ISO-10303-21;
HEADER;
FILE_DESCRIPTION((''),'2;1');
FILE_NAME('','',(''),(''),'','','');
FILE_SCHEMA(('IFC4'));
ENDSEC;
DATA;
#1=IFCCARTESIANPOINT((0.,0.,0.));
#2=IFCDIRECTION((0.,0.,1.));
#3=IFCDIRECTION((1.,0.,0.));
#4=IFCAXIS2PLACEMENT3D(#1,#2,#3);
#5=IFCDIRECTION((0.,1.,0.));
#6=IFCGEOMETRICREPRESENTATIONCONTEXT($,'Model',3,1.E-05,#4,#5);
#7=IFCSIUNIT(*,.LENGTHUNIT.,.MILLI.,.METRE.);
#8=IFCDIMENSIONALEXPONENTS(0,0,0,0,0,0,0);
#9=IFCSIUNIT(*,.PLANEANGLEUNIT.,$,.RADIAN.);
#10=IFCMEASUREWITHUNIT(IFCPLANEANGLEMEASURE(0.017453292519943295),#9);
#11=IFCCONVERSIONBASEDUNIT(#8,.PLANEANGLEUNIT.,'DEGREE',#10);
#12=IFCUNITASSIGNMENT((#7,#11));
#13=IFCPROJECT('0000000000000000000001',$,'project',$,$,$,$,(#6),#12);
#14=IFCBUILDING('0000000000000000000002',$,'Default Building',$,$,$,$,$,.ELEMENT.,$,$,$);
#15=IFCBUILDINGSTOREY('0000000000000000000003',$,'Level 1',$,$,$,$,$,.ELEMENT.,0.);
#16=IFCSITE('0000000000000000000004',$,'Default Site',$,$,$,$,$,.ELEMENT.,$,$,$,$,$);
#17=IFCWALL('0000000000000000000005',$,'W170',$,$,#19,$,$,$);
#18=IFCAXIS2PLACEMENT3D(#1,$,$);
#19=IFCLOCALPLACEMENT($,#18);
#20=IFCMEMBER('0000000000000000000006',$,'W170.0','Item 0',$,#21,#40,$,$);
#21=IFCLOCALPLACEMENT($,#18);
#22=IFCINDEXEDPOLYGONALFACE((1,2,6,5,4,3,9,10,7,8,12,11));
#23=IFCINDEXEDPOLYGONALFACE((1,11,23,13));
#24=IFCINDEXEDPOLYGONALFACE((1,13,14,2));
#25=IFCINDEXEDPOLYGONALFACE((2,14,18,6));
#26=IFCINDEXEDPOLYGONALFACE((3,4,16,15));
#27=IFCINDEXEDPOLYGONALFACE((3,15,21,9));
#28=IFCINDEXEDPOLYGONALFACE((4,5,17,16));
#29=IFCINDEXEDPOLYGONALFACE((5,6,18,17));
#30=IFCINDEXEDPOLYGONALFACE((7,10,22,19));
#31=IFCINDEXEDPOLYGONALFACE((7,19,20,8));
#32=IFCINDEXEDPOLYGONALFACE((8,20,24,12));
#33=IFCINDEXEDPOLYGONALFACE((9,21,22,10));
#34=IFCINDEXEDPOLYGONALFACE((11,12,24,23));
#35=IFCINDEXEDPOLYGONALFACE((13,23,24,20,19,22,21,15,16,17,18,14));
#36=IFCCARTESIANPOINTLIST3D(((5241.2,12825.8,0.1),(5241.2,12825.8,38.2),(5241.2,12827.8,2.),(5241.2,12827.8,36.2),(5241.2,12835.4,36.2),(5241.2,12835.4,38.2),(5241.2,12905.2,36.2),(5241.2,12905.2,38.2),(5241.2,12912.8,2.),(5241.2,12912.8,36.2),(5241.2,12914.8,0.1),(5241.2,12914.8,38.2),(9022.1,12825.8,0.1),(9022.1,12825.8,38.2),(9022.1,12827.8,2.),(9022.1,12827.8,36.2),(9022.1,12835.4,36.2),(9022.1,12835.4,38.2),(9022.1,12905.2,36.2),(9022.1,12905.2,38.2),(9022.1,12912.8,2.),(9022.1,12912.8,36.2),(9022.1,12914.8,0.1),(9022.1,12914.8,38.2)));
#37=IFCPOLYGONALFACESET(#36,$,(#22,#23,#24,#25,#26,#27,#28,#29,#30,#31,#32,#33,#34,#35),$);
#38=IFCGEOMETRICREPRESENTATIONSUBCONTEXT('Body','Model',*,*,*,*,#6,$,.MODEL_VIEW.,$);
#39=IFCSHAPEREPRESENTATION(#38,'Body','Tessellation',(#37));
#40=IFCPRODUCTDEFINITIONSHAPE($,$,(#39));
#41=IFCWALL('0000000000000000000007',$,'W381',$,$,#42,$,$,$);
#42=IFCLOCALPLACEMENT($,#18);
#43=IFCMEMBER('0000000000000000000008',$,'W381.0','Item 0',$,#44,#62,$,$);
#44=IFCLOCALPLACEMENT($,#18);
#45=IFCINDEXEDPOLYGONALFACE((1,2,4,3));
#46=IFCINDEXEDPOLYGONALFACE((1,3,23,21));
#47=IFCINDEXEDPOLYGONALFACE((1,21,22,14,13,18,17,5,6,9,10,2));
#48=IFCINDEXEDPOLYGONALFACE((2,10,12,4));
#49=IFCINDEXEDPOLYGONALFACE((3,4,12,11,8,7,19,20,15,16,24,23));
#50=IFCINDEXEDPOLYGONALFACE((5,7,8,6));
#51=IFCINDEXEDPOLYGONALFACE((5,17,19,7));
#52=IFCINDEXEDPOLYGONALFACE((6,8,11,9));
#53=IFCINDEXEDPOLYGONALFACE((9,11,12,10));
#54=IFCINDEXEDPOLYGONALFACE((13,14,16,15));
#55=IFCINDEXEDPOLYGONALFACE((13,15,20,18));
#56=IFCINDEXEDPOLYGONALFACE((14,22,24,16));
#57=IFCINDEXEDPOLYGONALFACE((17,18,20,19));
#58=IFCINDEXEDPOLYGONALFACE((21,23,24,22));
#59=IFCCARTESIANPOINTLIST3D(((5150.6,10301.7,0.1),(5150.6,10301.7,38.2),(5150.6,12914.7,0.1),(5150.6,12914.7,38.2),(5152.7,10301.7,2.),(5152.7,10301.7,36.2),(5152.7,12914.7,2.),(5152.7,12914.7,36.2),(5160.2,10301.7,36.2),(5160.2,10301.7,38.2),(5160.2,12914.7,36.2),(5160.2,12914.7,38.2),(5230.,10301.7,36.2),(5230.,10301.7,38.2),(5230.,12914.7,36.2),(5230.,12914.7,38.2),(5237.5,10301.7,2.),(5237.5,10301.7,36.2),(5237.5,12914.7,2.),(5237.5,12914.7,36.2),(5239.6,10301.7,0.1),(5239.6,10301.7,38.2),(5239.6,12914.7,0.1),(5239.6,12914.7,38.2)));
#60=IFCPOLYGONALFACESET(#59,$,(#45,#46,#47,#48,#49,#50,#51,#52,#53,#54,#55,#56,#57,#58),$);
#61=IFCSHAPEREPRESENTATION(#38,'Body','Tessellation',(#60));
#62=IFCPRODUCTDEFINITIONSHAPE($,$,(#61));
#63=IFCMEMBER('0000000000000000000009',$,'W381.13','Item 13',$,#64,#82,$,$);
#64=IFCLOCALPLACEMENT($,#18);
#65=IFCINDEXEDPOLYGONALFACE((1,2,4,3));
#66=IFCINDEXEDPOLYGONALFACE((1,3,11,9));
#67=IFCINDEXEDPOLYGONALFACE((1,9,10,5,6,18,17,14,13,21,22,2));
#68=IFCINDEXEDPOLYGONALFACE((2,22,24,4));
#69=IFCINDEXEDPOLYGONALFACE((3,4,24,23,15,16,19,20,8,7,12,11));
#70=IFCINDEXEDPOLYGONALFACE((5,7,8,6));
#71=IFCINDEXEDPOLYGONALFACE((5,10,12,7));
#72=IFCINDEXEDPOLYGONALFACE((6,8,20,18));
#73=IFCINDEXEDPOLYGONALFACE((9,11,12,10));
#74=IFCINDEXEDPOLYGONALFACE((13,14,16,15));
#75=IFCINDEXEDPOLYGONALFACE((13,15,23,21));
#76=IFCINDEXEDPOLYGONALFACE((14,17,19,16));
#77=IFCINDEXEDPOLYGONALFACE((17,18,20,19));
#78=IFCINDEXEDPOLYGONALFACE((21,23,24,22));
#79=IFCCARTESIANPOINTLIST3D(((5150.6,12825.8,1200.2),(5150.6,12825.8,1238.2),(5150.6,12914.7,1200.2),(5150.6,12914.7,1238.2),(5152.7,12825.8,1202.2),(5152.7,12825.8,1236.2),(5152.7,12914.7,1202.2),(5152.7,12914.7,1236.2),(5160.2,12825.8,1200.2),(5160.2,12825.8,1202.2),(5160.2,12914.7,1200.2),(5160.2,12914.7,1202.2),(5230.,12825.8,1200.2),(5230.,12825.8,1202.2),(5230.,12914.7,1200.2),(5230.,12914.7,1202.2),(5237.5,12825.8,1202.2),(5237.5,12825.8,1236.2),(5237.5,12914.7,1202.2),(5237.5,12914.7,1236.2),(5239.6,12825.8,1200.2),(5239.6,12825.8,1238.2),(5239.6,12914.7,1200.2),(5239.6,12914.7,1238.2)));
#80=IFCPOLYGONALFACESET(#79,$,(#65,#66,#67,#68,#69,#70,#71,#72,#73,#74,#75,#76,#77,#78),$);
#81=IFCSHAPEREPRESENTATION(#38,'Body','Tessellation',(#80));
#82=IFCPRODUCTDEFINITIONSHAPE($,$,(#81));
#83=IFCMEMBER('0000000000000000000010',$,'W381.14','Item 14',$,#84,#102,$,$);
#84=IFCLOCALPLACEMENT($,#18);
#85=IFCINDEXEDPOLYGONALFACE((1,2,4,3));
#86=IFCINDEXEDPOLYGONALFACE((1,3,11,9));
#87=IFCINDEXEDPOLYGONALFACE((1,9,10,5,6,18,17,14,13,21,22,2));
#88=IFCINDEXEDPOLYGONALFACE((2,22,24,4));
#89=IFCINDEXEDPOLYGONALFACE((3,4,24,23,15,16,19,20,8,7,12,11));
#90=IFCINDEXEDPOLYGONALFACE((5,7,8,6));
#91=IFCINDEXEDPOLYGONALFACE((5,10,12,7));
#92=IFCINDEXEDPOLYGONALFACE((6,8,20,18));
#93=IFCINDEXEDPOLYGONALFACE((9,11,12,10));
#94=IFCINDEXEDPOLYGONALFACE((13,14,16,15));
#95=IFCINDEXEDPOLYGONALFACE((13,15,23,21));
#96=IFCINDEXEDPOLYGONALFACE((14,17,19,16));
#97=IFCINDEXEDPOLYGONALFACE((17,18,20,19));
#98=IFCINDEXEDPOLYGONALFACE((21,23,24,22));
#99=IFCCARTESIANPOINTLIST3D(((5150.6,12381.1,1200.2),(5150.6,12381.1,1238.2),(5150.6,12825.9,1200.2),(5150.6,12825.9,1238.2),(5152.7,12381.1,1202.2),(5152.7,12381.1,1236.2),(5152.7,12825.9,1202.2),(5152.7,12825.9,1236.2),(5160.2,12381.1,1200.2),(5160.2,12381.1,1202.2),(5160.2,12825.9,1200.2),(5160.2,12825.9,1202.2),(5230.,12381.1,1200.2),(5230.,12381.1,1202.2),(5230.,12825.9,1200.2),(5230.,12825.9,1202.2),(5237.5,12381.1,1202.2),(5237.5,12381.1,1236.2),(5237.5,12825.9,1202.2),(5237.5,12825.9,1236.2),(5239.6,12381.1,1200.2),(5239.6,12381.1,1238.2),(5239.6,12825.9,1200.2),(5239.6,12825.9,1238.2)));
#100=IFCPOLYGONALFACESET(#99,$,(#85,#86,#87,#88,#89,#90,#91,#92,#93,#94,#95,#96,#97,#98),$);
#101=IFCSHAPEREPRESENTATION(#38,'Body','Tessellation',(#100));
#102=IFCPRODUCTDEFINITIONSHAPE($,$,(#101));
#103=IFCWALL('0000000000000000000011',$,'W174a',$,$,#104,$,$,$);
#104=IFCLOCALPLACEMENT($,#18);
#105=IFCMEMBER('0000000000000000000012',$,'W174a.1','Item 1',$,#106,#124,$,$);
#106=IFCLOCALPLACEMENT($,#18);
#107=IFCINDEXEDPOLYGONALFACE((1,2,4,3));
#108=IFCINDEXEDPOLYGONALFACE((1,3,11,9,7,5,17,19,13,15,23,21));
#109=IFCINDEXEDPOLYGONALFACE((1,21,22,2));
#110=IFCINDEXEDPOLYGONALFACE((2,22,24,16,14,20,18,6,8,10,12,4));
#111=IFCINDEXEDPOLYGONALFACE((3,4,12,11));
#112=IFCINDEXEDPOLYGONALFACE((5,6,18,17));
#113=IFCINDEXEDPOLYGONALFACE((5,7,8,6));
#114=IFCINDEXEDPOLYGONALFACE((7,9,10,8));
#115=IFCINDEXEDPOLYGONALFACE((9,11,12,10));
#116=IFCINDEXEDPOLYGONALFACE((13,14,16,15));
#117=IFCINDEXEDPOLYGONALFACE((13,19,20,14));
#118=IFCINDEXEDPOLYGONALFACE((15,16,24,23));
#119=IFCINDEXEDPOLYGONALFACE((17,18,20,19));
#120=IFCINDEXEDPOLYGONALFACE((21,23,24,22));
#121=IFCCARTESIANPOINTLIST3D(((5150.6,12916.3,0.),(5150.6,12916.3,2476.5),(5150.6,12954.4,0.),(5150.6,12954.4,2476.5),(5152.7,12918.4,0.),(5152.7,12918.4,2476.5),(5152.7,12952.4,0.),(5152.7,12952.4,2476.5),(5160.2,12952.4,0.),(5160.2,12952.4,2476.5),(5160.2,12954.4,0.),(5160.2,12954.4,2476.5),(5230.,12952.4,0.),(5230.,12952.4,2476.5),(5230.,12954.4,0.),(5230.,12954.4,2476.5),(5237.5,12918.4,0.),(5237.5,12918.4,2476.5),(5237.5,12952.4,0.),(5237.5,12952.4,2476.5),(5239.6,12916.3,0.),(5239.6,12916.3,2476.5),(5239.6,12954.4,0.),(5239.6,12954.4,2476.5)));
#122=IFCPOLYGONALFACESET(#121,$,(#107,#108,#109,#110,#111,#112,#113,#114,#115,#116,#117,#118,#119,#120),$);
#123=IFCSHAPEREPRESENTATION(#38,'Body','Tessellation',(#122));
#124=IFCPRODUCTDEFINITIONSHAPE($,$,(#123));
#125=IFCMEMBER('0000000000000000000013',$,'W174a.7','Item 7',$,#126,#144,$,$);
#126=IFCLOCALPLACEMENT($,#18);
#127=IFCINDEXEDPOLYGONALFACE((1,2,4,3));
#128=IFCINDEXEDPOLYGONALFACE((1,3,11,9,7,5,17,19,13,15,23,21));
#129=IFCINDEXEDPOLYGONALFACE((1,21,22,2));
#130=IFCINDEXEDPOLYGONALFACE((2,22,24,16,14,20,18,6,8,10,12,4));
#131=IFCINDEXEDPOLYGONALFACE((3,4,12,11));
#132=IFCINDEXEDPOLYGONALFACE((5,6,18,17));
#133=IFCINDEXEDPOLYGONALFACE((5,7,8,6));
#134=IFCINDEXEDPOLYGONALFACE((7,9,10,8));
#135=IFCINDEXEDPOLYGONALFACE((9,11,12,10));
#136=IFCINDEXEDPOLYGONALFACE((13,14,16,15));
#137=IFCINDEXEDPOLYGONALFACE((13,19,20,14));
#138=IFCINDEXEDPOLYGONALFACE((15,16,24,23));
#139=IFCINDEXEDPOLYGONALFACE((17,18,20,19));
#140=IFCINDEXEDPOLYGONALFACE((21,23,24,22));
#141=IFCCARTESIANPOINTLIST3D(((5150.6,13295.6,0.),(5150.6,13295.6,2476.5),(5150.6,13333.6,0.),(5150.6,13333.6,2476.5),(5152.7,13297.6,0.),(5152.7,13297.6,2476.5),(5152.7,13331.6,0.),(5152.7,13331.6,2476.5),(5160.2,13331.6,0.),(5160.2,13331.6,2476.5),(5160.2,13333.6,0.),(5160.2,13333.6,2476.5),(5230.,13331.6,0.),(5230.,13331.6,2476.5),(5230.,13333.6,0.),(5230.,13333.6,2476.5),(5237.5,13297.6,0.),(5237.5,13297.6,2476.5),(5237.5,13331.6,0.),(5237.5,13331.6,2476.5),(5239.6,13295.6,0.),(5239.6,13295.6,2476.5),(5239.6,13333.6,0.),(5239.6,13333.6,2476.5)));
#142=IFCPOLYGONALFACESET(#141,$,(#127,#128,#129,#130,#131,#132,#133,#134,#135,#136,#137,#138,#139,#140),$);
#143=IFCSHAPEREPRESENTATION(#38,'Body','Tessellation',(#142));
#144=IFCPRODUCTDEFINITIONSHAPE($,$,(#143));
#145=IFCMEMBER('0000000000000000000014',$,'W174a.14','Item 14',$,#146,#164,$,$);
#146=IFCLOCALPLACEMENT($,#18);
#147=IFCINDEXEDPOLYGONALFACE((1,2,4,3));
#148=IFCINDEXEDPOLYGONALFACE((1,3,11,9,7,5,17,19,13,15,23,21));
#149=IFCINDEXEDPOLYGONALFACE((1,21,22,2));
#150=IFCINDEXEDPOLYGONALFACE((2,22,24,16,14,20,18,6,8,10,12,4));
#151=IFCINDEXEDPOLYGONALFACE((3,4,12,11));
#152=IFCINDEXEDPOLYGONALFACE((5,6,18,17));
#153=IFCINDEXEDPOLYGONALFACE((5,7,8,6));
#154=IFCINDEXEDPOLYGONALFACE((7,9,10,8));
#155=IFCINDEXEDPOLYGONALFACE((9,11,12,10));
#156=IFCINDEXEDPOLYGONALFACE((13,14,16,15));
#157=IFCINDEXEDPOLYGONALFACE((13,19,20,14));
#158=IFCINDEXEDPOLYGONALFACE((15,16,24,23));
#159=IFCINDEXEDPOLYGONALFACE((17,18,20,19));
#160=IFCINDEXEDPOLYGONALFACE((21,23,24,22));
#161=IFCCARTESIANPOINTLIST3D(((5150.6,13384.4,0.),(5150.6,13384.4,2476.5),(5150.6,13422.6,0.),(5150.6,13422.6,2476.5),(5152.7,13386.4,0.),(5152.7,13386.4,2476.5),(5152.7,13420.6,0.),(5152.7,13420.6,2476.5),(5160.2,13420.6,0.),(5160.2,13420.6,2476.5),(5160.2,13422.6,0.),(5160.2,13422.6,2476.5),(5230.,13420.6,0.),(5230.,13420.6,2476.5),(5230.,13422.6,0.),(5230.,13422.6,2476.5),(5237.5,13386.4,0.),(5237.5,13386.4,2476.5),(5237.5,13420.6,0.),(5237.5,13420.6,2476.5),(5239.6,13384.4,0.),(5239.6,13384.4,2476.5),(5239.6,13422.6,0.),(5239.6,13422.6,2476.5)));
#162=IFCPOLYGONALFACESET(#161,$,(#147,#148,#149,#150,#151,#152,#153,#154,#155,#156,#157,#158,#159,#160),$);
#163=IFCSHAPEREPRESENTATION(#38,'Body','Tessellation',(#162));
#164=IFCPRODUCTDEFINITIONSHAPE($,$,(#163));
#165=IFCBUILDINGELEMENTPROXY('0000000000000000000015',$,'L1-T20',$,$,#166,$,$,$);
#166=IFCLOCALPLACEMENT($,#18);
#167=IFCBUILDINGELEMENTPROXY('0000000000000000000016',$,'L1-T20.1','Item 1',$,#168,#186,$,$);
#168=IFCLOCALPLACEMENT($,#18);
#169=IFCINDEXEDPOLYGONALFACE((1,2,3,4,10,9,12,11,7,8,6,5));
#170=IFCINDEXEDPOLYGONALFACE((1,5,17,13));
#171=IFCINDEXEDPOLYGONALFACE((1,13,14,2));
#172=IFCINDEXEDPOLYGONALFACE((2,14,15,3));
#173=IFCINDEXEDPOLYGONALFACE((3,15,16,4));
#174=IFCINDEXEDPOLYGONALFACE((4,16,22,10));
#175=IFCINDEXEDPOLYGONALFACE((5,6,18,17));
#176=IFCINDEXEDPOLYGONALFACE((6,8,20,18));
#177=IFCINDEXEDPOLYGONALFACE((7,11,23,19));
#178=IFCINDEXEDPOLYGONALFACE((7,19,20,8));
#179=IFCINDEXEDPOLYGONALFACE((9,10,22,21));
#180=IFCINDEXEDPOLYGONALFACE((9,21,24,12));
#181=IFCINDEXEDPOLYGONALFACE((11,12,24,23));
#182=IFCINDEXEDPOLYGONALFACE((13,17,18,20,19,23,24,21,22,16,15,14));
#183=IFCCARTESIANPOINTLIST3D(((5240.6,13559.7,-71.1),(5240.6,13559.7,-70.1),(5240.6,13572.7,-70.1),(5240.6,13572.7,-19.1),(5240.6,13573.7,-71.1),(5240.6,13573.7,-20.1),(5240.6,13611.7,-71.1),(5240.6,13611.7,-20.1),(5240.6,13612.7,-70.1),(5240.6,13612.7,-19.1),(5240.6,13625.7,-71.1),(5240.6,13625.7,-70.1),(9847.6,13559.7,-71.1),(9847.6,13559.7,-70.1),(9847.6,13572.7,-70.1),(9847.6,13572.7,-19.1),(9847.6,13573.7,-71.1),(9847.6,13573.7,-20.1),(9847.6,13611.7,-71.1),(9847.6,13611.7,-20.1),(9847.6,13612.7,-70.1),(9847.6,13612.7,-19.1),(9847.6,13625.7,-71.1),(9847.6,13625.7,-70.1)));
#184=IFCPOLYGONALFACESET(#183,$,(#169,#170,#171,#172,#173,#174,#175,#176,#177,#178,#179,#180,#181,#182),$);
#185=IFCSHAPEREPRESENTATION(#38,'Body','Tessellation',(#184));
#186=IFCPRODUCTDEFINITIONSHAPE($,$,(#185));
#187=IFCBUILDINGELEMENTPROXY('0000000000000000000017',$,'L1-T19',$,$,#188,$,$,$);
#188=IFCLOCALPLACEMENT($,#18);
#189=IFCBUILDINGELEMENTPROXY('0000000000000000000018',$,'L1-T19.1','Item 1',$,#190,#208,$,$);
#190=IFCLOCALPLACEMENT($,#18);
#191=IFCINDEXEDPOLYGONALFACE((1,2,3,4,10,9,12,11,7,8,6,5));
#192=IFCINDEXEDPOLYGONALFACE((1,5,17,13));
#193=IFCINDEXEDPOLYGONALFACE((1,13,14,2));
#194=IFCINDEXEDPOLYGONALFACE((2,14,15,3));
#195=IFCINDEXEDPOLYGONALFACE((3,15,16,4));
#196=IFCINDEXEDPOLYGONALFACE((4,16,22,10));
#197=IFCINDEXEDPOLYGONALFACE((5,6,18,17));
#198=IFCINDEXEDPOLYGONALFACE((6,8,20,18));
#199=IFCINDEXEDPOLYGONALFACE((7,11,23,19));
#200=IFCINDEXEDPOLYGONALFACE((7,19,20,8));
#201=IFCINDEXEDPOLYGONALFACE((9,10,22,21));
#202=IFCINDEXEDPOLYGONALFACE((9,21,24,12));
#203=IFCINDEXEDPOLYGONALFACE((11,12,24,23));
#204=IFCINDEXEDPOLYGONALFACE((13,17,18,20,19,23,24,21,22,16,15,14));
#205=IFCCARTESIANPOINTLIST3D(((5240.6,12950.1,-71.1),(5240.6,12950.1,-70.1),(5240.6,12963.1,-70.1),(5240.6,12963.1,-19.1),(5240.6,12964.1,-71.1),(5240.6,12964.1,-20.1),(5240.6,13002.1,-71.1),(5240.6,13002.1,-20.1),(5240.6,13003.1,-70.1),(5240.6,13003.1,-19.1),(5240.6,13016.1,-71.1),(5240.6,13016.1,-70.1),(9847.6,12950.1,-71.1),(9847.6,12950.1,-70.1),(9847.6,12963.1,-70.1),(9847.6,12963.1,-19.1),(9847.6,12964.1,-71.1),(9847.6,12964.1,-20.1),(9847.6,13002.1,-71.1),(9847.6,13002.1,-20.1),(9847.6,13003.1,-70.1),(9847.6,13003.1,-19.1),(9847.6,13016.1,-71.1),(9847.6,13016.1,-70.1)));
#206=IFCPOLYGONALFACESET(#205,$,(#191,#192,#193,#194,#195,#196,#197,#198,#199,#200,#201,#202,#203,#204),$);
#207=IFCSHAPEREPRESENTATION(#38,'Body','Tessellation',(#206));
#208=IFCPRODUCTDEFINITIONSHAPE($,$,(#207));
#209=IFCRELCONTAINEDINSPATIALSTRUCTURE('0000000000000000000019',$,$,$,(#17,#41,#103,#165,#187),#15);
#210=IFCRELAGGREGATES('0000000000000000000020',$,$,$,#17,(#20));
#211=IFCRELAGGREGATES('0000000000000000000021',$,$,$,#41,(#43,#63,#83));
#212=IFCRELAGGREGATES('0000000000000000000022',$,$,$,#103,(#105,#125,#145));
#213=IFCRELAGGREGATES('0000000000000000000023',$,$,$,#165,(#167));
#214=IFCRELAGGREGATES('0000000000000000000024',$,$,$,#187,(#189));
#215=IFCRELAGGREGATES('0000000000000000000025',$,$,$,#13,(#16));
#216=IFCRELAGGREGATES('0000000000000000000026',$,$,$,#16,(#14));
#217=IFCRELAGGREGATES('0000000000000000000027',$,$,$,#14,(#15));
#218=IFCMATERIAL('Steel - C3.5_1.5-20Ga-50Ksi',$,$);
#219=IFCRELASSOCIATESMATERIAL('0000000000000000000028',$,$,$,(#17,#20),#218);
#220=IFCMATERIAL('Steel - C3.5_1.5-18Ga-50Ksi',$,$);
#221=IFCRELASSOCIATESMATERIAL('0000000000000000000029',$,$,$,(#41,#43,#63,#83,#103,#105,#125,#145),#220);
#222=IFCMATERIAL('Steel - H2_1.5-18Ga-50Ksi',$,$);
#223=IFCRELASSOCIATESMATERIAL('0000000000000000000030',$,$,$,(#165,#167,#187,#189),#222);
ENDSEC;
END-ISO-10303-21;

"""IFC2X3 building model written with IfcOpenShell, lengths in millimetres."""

from ifc_helpers import new_model, entity, si_unit, converted_unit, direction, frame, origin, origin_with_axes, origin_2d_with_axis, place, context, subcontext, project, spatial, polyline, c_section, outline, extrude, material, element, aggregate, save


model = new_model("IFC2X3")

# Units and contexts
model_context = context("Model", 3, precision=1e-05, world=origin_with_axes(), true_north=direction((0.0, 1.0, 0.0)))
body_context = subcontext(model_context, "Body", "Model", "MODEL_VIEW")
ifc_project = project(units=[si_unit("LENGTHUNIT", "METRE", prefix="MILLI"), converted_unit("PLANEANGLEUNIT", "DEGREE", entity("IfcPlaneAngleMeasure", 0.017453292519943295), si_unit("PLANEANGLEUNIT", "RADIAN"), dimensions=[0, 0, 0, 0, 0, 0, 0])], contexts=[model_context])

# Site, building, storey
site = spatial("IfcSite", under=ifc_project, Name="Default Site", CompositionType="ELEMENT")
building = spatial("IfcBuilding", under=site, Name="Default Building", CompositionType="ELEMENT")
storey = spatial("IfcBuildingStorey", under=building, Name="Level 1", CompositionType="ELEMENT", Elevation=0.0)

# Wall, member
ifc_material_1 = material(Name="Steel - C3.5_1.5-20Ga-50Ksi")
wall_1 = element("IfcWall", 1, inside=storey, material=ifc_material_1, Name="W170")
member_1_placement = place(None, frame((5241.2, 12870.3, 19.1), z_axis=(1.0, 0.0, 0.0), x_axis=(0.0, 0.0, 1.0)))
member_1 = element("IfcMember", 2, at=member_1_placement, material=ifc_material_1, Name="W170.0", Description="Item 0", context=body_context, shape_type="SweptSolid", body=[
    extrude(c_section(Depth=88.9, Width=38.1, WallThickness=2.0, Girth=9.5, at=origin_2d_with_axis()), origin(), (0.0, 0.0, 1.0), 3780.9),
])
aggregate(wall_1, [member_1])

# Walls, members
ifc_material_2 = material(Name="Steel - C3.5_1.5-18Ga-50Ksi")
wall_2 = element("IfcWall", 3, inside=storey, material=ifc_material_2, Name="W381")
member_2_placement = place(None, frame((5195.1, 12914.7, 19.1), z_axis=(0.0, -1.0, 0.0), x_axis=(0.0, 0.0, 1.0)))
member_2 = element("IfcMember", 4, at=member_2_placement, material=ifc_material_2, Name="W381.0", Description="Item 0", context=body_context, shape_type="SweptSolid", body=[
    extrude(c_section(Depth=88.9, Width=38.1, WallThickness=2.0, Girth=9.5, at=origin_2d_with_axis()), origin(), (0.0, 0.0, 1.0), 2613.0),
])
member_3_placement = place(None, frame((5195.1, 12825.8, 1219.2), z_axis=(0.0, 1.0, 0.0), x_axis=(0.0, 0.0, -1.0)))
member_3 = element("IfcMember", 5, at=member_3_placement, material=ifc_material_2, Name="W381.13", Description="Item 13", context=body_context, shape_type="SweptSolid", body=[
    extrude(c_section(Depth=88.9, Width=38.1, WallThickness=2.0, Girth=9.5, at=origin_2d_with_axis()), origin(), (0.0, 0.0, 1.0), 88.9),
])
member_4_placement = place(None, frame((5195.1, 12381.1, 1219.2), z_axis=(0.0, 1.0, 0.0), x_axis=(0.0, 0.0, -1.0)))
member_4 = element("IfcMember", 6, at=member_4_placement, material=ifc_material_2, Name="W381.14", Description="Item 14", context=body_context, shape_type="SweptSolid", body=[
    extrude(c_section(Depth=88.9, Width=38.1, WallThickness=2.0, Girth=9.5, at=origin_2d_with_axis()), origin(), (0.0, 0.0, 1.0), 444.8),
])
aggregate(wall_2, [member_2, member_3, member_4])
wall_3 = element("IfcWall", 7, inside=storey, material=ifc_material_2, Name="W174a")
member_5_placement = place(None, frame((5195.1, 12935.4, 0.0), z_axis=(0.0, 0.0, 1.0), x_axis=(0.0, 1.0, 0.0)))
member_5 = element("IfcMember", 8, at=member_5_placement, material=ifc_material_2, Name="W174a.1", Description="Item 1", context=body_context, shape_type="SweptSolid", body=[
    extrude(c_section(Depth=88.9, Width=38.1, WallThickness=2.0, Girth=9.5, at=origin_2d_with_axis()), origin(), (0.0, 0.0, 1.0), 2476.5),
])
member_6_placement = place(None, frame((5195.1, 13314.6, 0.0), z_axis=(0.0, 0.0, 1.0), x_axis=(0.0, 1.0, 0.0)))
member_6 = element("IfcMember", 9, at=member_6_placement, material=ifc_material_2, Name="W174a.7", Description="Item 7", context=body_context, shape_type="SweptSolid", body=[
    extrude(c_section(Depth=88.9, Width=38.1, WallThickness=2.0, Girth=9.5, at=origin_2d_with_axis()), origin(), (0.0, 0.0, 1.0), 2476.5),
])
member_7_placement = place(None, frame((5195.1, 13403.5, 0.0), z_axis=(0.0, 0.0, 1.0), x_axis=(0.0, 1.0, 0.0)))
member_7 = element("IfcMember", 10, at=member_7_placement, material=ifc_material_2, Name="W174a.14", Description="Item 14", context=body_context, shape_type="SweptSolid", body=[
    extrude(c_section(Depth=88.9, Width=38.1, WallThickness=2.0, Girth=9.5, at=origin_2d_with_axis()), origin(), (0.0, 0.0, 1.0), 2476.5),
])
aggregate(wall_3, [member_5, member_6, member_7])

# Building element proxies
ifc_material_3 = material(Name="Steel - H2_1.5-18Ga-50Ksi")
proxy_1 = element("IfcBuildingElementProxy", 11, inside=storey, material=ifc_material_3, Name="L1-T20")
proxy_2_placement = place(None, frame((5240.6, 13559.7, -71.1), z_axis=(1.0, 0.0, 0.0), x_axis=(0.0, 40.0, 0.0)))
proxy_2 = element("IfcBuildingElementProxy", 12, at=proxy_2_placement, material=ifc_material_3, Name="L1-T20.1", Description="Item 1", context=body_context, shape_type="SweptSolid", body=[
    extrude(outline(polyline([(0.0, 0.0), (14.0, 0.0), (14.0, 51.0), (52.0, 51.0), (52.0, 0.0), (66.0, 0.0), (66.0, 1.0), (53.0, 1.0), (53.0, 52.0), (13.0, 52.0), (13.0, 1.0), (0.0, 1.0), (0.0, 0.0)])), origin(), (0.0, 0.0, 1.0), 4607.0),
])
aggregate(proxy_1, [proxy_2])
proxy_3 = element("IfcBuildingElementProxy", 13, inside=storey, material=ifc_material_3, Name="L1-T19")
proxy_4_placement = place(None, frame((5240.6, 12950.1, -71.1), z_axis=(1.0, 0.0, 0.0), x_axis=(0.0, 40.0, 0.0)))
proxy_4 = element("IfcBuildingElementProxy", 14, at=proxy_4_placement, material=ifc_material_3, Name="L1-T19.1", Description="Item 1", context=body_context, shape_type="SweptSolid", body=[
    extrude(outline(polyline([(0.0, 0.0), (14.0, 0.0), (14.0, 51.0), (52.0, 51.0), (52.0, 0.0), (66.0, 0.0), (66.0, 1.0), (53.0, 1.0), (53.0, 52.0), (13.0, 52.0), (13.0, 1.0), (0.0, 1.0), (0.0, 0.0)])), origin(), (0.0, 0.0, 1.0), 4607.0),
])
aggregate(proxy_3, [proxy_4])

save(model, "model.ifc")
